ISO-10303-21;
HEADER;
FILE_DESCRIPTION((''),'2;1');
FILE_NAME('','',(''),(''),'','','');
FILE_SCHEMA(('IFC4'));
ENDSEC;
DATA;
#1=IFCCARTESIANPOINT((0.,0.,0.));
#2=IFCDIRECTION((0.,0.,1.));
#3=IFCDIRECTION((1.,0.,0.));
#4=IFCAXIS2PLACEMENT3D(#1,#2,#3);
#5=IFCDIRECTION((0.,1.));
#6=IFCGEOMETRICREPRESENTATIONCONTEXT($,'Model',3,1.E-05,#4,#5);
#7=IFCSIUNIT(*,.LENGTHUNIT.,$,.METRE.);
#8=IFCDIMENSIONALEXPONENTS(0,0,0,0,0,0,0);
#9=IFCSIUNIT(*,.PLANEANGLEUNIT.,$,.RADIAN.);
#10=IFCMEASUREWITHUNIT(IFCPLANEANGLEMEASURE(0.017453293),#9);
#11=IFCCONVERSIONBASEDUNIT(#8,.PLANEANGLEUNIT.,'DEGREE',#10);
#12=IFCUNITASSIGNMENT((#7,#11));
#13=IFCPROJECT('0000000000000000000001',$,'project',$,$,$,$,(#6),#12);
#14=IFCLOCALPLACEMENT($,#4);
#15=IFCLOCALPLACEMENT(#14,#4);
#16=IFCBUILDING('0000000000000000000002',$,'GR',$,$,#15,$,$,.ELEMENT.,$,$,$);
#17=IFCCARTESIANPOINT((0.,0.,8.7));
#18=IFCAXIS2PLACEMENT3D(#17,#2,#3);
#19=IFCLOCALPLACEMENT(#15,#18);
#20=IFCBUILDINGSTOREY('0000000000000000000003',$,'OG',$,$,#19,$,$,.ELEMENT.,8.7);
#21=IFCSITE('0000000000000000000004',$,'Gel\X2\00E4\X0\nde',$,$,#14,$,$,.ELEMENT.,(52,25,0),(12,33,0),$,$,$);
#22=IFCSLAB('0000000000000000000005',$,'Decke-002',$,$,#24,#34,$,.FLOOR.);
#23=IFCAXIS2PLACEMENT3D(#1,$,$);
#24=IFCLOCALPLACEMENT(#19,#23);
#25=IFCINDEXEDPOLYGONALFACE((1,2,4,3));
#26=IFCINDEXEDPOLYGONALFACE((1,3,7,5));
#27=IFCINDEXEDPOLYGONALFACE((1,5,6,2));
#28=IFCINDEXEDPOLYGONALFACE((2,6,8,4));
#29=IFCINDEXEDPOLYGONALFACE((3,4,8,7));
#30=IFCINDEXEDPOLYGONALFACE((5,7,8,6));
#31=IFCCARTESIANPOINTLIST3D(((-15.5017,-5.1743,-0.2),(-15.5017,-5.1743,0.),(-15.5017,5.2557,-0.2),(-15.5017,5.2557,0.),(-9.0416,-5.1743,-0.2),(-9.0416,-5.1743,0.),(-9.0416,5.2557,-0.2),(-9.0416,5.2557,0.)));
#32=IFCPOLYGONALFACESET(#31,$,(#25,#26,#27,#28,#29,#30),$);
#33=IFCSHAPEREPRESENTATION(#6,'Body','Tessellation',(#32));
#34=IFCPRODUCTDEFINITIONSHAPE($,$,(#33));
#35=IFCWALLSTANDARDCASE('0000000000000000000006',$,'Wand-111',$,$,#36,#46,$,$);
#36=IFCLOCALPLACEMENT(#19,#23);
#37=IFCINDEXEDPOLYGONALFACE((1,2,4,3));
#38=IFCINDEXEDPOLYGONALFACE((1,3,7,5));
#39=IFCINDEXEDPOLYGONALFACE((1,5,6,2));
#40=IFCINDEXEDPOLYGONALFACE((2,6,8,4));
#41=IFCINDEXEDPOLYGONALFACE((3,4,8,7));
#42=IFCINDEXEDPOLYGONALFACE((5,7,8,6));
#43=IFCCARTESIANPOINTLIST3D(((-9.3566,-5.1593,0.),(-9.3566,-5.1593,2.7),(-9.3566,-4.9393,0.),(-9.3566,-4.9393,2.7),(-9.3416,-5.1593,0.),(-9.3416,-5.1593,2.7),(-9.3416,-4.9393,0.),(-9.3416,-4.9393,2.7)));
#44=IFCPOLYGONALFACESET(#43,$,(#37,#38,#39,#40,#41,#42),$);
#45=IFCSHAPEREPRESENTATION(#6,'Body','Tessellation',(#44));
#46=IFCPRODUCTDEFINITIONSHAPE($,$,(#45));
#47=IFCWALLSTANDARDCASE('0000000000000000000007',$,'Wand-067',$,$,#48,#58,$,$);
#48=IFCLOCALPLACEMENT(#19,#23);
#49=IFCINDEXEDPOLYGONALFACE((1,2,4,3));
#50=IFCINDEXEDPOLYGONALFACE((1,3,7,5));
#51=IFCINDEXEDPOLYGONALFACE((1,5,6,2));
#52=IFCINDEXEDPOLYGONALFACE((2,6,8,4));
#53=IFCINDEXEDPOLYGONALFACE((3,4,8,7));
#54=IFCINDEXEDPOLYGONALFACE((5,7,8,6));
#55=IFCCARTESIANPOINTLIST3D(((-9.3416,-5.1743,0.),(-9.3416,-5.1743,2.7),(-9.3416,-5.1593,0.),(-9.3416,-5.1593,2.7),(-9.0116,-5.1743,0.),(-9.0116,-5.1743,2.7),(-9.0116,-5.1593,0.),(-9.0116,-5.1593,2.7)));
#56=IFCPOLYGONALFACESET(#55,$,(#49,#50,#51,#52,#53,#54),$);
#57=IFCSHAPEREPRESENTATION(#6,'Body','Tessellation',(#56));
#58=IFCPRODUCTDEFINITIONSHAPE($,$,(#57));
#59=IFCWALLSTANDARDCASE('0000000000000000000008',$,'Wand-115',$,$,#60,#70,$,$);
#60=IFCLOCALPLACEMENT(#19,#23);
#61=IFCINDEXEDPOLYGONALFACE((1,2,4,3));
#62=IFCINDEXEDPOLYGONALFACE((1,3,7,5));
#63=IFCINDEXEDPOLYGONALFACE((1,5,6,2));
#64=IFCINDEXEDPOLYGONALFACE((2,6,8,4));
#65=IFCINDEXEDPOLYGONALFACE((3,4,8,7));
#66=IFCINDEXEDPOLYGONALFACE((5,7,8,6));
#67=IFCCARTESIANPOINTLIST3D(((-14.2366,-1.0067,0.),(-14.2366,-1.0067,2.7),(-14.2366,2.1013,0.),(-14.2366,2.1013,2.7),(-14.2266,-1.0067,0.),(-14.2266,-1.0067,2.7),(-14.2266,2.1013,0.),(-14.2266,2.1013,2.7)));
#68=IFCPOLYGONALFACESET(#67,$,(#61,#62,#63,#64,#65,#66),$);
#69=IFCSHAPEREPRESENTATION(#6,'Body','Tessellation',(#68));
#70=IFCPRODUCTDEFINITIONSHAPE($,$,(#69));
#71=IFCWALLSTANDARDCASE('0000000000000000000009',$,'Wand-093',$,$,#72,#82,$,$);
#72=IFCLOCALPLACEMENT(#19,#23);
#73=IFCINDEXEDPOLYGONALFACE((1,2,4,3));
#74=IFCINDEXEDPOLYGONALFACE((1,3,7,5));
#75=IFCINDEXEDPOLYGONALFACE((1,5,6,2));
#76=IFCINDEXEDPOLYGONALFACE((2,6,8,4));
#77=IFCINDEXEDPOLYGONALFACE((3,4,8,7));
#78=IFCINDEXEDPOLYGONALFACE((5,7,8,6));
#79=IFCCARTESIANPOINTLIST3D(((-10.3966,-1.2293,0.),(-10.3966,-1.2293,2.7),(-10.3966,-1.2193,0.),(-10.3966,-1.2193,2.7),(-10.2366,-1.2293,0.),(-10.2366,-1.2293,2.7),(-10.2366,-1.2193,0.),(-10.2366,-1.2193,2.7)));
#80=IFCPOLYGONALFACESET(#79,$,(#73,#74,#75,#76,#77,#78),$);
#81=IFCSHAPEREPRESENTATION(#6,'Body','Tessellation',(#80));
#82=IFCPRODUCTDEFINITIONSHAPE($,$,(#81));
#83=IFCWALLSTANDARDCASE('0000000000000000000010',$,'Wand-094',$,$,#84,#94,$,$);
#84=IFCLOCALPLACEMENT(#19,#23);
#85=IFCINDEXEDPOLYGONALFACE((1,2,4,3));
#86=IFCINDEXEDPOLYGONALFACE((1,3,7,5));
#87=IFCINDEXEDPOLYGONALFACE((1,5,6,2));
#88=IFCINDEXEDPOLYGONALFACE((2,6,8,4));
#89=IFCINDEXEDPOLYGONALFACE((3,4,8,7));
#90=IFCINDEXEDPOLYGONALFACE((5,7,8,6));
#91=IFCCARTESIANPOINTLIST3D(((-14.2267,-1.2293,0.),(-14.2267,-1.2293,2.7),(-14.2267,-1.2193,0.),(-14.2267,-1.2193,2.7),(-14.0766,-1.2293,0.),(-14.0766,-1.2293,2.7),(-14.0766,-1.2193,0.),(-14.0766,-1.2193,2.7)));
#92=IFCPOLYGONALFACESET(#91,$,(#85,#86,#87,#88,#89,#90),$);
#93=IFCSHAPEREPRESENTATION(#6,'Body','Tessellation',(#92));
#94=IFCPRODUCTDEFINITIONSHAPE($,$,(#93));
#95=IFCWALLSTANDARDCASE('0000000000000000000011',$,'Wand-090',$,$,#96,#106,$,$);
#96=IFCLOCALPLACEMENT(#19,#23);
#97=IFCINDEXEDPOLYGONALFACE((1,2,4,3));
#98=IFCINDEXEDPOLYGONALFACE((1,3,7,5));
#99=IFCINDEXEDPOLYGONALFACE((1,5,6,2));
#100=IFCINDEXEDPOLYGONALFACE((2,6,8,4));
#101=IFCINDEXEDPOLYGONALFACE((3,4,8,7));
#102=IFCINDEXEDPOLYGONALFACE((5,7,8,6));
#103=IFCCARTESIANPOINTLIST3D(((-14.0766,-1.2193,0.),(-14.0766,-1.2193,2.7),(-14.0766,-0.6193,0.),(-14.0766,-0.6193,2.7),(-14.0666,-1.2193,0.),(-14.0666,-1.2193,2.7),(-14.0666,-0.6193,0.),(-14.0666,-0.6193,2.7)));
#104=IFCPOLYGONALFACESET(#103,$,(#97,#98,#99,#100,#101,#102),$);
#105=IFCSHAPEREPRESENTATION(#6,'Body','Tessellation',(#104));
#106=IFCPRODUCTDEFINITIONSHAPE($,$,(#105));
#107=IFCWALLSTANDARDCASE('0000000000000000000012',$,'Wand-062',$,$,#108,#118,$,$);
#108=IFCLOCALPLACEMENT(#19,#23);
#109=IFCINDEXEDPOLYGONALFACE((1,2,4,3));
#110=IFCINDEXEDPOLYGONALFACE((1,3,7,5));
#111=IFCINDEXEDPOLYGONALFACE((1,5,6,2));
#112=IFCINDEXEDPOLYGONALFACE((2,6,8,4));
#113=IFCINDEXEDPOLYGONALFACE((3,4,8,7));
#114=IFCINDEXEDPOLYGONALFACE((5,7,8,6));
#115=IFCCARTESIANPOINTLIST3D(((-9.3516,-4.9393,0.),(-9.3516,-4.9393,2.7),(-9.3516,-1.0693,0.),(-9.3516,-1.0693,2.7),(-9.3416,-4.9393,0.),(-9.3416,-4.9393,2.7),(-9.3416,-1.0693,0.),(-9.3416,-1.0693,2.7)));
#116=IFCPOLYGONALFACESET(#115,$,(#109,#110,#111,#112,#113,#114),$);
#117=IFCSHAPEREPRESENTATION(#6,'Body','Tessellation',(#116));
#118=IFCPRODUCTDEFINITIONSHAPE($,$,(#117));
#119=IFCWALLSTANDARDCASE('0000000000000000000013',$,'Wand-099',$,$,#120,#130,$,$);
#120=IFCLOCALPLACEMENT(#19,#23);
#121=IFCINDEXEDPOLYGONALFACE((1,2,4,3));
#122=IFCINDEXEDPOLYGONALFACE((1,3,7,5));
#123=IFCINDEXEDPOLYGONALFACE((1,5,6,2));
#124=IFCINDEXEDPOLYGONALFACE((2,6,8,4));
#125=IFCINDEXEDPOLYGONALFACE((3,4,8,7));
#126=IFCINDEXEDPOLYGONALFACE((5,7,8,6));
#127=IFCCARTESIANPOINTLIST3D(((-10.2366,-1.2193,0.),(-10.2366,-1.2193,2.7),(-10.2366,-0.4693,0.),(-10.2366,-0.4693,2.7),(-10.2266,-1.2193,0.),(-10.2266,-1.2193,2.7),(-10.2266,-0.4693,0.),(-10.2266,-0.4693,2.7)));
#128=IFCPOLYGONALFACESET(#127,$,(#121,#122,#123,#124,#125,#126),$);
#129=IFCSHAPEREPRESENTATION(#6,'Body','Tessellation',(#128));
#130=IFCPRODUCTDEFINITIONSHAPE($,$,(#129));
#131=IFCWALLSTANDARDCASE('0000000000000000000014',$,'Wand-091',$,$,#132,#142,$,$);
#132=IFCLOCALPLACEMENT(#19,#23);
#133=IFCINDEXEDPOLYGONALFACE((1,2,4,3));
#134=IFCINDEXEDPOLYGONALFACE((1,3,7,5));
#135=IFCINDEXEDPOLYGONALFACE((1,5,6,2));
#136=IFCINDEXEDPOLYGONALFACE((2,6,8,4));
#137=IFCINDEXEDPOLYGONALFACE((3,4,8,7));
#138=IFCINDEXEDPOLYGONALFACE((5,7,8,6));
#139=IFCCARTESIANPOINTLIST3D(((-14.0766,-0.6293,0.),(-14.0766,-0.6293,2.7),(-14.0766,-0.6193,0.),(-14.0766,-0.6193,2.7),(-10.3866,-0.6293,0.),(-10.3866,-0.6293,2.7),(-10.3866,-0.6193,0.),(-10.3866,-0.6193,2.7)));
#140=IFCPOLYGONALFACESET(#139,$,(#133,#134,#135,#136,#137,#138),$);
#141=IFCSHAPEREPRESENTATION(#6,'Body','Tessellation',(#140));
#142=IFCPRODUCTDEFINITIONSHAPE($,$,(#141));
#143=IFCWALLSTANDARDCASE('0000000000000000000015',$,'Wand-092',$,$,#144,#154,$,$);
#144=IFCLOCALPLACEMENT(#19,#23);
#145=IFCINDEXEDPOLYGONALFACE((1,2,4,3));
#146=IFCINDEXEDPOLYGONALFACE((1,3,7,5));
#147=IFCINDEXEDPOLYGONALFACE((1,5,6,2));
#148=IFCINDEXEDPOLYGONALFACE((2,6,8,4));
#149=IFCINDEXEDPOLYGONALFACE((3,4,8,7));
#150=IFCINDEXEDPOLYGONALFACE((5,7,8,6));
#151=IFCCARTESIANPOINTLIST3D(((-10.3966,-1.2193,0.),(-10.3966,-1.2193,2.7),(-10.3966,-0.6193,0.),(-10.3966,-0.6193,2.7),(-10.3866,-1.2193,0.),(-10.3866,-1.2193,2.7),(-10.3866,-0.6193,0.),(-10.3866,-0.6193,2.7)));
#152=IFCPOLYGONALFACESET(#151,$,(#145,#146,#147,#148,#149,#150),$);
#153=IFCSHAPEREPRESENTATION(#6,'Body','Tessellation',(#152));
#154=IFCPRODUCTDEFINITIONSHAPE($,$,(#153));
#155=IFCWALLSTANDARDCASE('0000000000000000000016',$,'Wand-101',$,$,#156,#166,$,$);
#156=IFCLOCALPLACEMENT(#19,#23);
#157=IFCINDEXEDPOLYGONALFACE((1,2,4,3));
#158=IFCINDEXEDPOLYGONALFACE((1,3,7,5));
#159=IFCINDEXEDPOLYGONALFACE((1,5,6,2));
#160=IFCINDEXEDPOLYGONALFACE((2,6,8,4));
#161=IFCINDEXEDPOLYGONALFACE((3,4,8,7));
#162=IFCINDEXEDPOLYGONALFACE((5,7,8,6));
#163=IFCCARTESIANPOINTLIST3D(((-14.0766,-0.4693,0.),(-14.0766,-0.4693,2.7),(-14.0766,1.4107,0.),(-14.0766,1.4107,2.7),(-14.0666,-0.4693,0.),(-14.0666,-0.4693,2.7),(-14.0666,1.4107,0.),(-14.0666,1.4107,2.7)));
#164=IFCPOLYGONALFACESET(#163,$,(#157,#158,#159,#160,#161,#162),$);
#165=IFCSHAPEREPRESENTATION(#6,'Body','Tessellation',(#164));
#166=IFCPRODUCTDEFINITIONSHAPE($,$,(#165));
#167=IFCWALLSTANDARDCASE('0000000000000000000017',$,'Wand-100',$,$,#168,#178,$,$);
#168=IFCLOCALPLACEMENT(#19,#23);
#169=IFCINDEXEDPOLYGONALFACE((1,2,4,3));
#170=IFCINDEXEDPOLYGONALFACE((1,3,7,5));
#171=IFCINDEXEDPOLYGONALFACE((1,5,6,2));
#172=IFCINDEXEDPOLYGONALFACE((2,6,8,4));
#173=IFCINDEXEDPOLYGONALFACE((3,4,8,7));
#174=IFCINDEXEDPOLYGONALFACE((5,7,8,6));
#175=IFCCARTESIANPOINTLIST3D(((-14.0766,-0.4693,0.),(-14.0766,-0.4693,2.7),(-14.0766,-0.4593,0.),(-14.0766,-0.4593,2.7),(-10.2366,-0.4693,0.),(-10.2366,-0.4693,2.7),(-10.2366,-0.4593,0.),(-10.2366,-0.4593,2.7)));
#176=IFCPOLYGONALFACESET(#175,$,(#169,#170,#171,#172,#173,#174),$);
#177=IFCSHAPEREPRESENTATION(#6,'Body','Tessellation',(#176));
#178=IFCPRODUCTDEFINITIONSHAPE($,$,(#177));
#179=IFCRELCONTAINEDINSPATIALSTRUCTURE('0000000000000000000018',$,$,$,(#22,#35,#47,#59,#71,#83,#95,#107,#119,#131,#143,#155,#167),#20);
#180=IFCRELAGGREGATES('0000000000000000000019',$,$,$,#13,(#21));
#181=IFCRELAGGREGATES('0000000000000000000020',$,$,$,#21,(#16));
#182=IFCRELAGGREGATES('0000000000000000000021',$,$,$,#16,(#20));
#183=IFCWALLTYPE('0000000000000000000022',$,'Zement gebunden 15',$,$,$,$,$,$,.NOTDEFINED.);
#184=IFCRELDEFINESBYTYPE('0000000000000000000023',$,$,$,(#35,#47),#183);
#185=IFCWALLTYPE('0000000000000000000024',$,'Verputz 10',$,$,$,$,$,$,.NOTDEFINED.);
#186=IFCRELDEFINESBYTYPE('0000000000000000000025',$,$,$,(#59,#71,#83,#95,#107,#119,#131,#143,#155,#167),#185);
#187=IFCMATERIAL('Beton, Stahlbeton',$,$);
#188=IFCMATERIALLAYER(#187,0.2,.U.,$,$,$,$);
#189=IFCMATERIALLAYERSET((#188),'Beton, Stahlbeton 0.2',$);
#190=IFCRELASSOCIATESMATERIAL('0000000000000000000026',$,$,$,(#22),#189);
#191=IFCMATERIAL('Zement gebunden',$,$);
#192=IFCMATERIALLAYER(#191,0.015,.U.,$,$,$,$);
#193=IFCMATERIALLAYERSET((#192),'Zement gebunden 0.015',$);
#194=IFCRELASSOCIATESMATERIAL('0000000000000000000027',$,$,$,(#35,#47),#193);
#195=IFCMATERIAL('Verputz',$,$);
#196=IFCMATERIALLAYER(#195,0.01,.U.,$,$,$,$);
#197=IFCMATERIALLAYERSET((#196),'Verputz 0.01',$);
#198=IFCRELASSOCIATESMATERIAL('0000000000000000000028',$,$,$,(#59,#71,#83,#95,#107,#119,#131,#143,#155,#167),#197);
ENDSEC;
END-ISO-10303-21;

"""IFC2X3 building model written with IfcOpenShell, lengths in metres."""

from ifc_helpers import new_model, entity, si_unit, converted_unit, direction, frame, origin_with_axes, place, context, project, spatial, polyline, outline, extrude, material, layer, layer_set, layer_usage, type_object, element, save


model = new_model("IFC2X3")

# Units and contexts
model_context = context("Model", 3, precision=1e-05, world=origin_with_axes(), true_north=direction((0.0, 1.0)))
ifc_project = project(units=[si_unit("LENGTHUNIT", "METRE"), converted_unit("PLANEANGLEUNIT", "DEGREE", entity("IfcPlaneAngleMeasure", 0.017453293), si_unit("PLANEANGLEUNIT", "RADIAN"), dimensions=[0, 0, 0, 0, 0, 0, 0])], contexts=[model_context])

# Site, building, storey
site_placement = place(None, origin_with_axes())
site = spatial("IfcSite", under=ifc_project, at=site_placement, Name="Gelände", CompositionType="ELEMENT", RefLatitude=(52, 25, 0), RefLongitude=(12, 33, 0))
building_placement = place(site_placement, origin_with_axes())
building = spatial("IfcBuilding", under=site, at=building_placement, Name="GR", CompositionType="ELEMENT")
storey_placement = place(building_placement, frame((0.0, 0.0, 8.7), z_axis=(0.0, 0.0, 1.0), x_axis=(1.0, 0.0, 0.0)))
storey = spatial("IfcBuildingStorey", under=building, at=storey_placement, Name="OG", CompositionType="ELEMENT", Elevation=8.7)

# Slab
ifc_material_1 = material(Name="Beton, Stahlbeton")
ifc_layer_1 = layer(ifc_material_1, 0.2, ventilated="UNKNOWN")
ifc_layer_set_1 = layer_set([ifc_layer_1], Name="Beton, Stahlbeton 0.2")
ifc_layer_usage_1 = layer_usage(ifc_layer_set_1, "AXIS3", "NEGATIVE", 0.2)
slab_placement = place(storey_placement, frame((-9.0416, -5.1743, -0.2), z_axis=(0.0, 0.0, 1.0), x_axis=(1.0, 0.0, 0.0)))
element("IfcSlab", 1, at=slab_placement, inside=storey, material=ifc_layer_usage_1, Name="Decke-002", PredefinedType="FLOOR", context=model_context, shape_type="SweptSolid", body=[
    extrude(outline(polyline([(0.0, 0.0), (0.0, 10.43), (-6.46, 10.43), (-6.46, 0.0), (0.0, 0.0)])), origin_with_axes(), (0.0, 0.0, 1.0), 0.2),
])

# Walls
ifc_material_2 = material(Name="Zement gebunden")
ifc_layer_2 = layer(ifc_material_2, 0.015, ventilated="UNKNOWN")
ifc_layer_set_2 = layer_set([ifc_layer_2], Name="Zement gebunden 0.015")
ifc_layer_usage_2 = layer_usage(ifc_layer_set_2, "AXIS2", "NEGATIVE", 0.0)
wall_type_1 = type_object("IfcWallType", Name="Zement gebunden 15", PredefinedType="NOTDEFINED")
wall_1_placement = place(storey_placement, frame((-9.3416, -4.9393, 0.0), z_axis=(0.0, 0.0, 1.0), x_axis=(0.0, -1.0, 0.0)))
element("IfcWallStandardCase", 2, at=wall_1_placement, inside=storey, type_object=wall_type_1, material=ifc_layer_usage_2, Name="Wand-111", context=model_context, shape_type="SweptSolid", body=[
    extrude(outline(polyline([(0.0, -0.015), (0.22, -0.015), (0.22, 0.0), (0.0, 0.0), (0.0, -0.015)])), origin_with_axes(), (0.0, 0.0, 1.0), 2.7),
])
ifc_layer_usage_3 = layer_usage(ifc_layer_set_2, "AXIS2", "NEGATIVE", 0.0)
wall_2_placement = place(storey_placement, frame((-9.3416, -5.1593, 0.0), z_axis=(0.0, 0.0, 1.0), x_axis=(1.0, 0.0, 0.0)))
element("IfcWallStandardCase", 3, at=wall_2_placement, inside=storey, type_object=wall_type_1, material=ifc_layer_usage_3, Name="Wand-067", context=model_context, shape_type="SweptSolid", body=[
    extrude(outline(polyline([(0.0, -0.015), (0.33, -0.015), (0.33, 0.0), (0.0, 0.0), (0.0, -0.015)])), origin_with_axes(), (0.0, 0.0, 1.0), 2.7),
])
ifc_material_3 = material(Name="Verputz")
ifc_layer_3 = layer(ifc_material_3, 0.01, ventilated="UNKNOWN")
ifc_layer_set_3 = layer_set([ifc_layer_3], Name="Verputz 0.01")
ifc_layer_usage_4 = layer_usage(ifc_layer_set_3, "AXIS2", "POSITIVE", 0.0)
wall_type_2 = type_object("IfcWallType", Name="Verputz 10", PredefinedType="NOTDEFINED")
wall_3_placement = place(storey_placement, frame((-14.2266, -1.0067, 0.0), z_axis=(0.0, 0.0, 1.0), x_axis=(0.0, 1.0, 0.0)))
element("IfcWallStandardCase", 4, at=wall_3_placement, inside=storey, type_object=wall_type_2, material=ifc_layer_usage_4, Name="Wand-115", context=model_context, shape_type="SweptSolid", body=[
    extrude(outline(polyline([(0.0, 0.0), (3.1079, 0.0), (3.1079, 0.01), (0.0, 0.01), (0.0, 0.0)])), origin_with_axes(), (0.0, 0.0, 1.0), 2.7),
])
ifc_layer_usage_5 = layer_usage(ifc_layer_set_3, "AXIS2", "NEGATIVE", 0.0)
wall_4_placement = place(storey_placement, frame((-10.3966, -1.2193, 0.0), z_axis=(0.0, 0.0, 1.0), x_axis=(1.0, 0.0, 0.0)))
element("IfcWallStandardCase", 5, at=wall_4_placement, inside=storey, type_object=wall_type_2, material=ifc_layer_usage_5, Name="Wand-093", context=model_context, shape_type="SweptSolid", body=[
    extrude(outline(polyline([(0.0, -0.01), (0.16, -0.01), (0.16, 0.0), (0.0, 0.0), (0.0, -0.01)])), origin_with_axes(), (0.0, 0.0, 1.0), 2.7),
])
ifc_layer_usage_6 = layer_usage(ifc_layer_set_3, "AXIS2", "NEGATIVE", 0.0)
wall_5_placement = place(storey_placement, frame((-14.2267, -1.2193, 0.0), z_axis=(0.0, 0.0, 1.0), x_axis=(1.0, 0.0, 0.0)))
element("IfcWallStandardCase", 6, at=wall_5_placement, inside=storey, type_object=wall_type_2, material=ifc_layer_usage_6, Name="Wand-094", context=model_context, shape_type="SweptSolid", body=[
    extrude(outline(polyline([(0.0, -0.01), (0.15, -0.01), (0.15, 0.0), (0.0, 0.0), (0.0, -0.01)])), origin_with_axes(), (0.0, 0.0, 1.0), 2.7),
])
ifc_layer_usage_7 = layer_usage(ifc_layer_set_3, "AXIS2", "NEGATIVE", 0.0)
wall_6_placement = place(storey_placement, frame((-14.0766, -1.2193, 0.0), z_axis=(0.0, 0.0, 1.0), x_axis=(0.0, 1.0, 0.0)))
element("IfcWallStandardCase", 7, at=wall_6_placement, inside=storey, type_object=wall_type_2, material=ifc_layer_usage_7, Name="Wand-090", context=model_context, shape_type="SweptSolid", body=[
    extrude(outline(polyline([(0.0, -0.01), (0.6, -0.01), (0.6, 0.0), (0.0, 0.0), (0.0, -0.01)])), origin_with_axes(), (0.0, 0.0, 1.0), 2.7),
])
ifc_layer_usage_8 = layer_usage(ifc_layer_set_3, "AXIS2", "NEGATIVE", 0.0)
wall_7_placement = place(storey_placement, frame((-9.3416, -1.0693, 0.0), z_axis=(0.0, 0.0, 1.0), x_axis=(0.0, -1.0, 0.0)))
element("IfcWallStandardCase", 8, at=wall_7_placement, inside=storey, type_object=wall_type_2, material=ifc_layer_usage_8, Name="Wand-062", context=model_context, shape_type="SweptSolid", body=[
    extrude(outline(polyline([(0.0, -0.01), (3.87, -0.01), (3.87, 0.0), (0.0, 0.0), (0.0, -0.01)])), origin_with_axes(), (0.0, 0.0, 1.0), 2.7),
])
ifc_layer_usage_9 = layer_usage(ifc_layer_set_3, "AXIS2", "NEGATIVE", 0.0)
wall_8_placement = place(storey_placement, frame((-10.2366, -1.2193, 0.0), z_axis=(0.0, 0.0, 1.0), x_axis=(0.0, 1.0, 0.0)))
element("IfcWallStandardCase", 9, at=wall_8_placement, inside=storey, type_object=wall_type_2, material=ifc_layer_usage_9, Name="Wand-099", context=model_context, shape_type="SweptSolid", body=[
    extrude(outline(polyline([(0.0, -0.01), (0.75, -0.01), (0.75, 0.0), (0.0, 0.0), (0.0, -0.01)])), origin_with_axes(), (0.0, 0.0, 1.0), 2.7),
])
ifc_layer_usage_10 = layer_usage(ifc_layer_set_3, "AXIS2", "NEGATIVE", 0.0)
wall_9_placement = place(storey_placement, frame((-14.0766, -0.6193, 0.0), z_axis=(0.0, 0.0, 1.0), x_axis=(1.0, 0.0, 0.0)))
element("IfcWallStandardCase", 10, at=wall_9_placement, inside=storey, type_object=wall_type_2, material=ifc_layer_usage_10, Name="Wand-091", context=model_context, shape_type="SweptSolid", body=[
    extrude(outline(polyline([(0.0, -0.01), (3.69, -0.01), (3.69, 0.0), (0.0, 0.0), (0.0, -0.01)])), origin_with_axes(), (0.0, 0.0, 1.0), 2.7),
])
ifc_layer_usage_11 = layer_usage(ifc_layer_set_3, "AXIS2", "NEGATIVE", 0.0)
wall_10_placement = place(storey_placement, frame((-10.3866, -0.6193, 0.0), z_axis=(0.0, 0.0, 1.0), x_axis=(0.0, -1.0, 0.0)))
element("IfcWallStandardCase", 11, at=wall_10_placement, inside=storey, type_object=wall_type_2, material=ifc_layer_usage_11, Name="Wand-092", context=model_context, shape_type="SweptSolid", body=[
    extrude(outline(polyline([(0.0, -0.01), (0.6, -0.01), (0.6, 0.0), (0.0, 0.0), (0.0, -0.01)])), origin_with_axes(), (0.0, 0.0, 1.0), 2.7),
])
ifc_layer_usage_12 = layer_usage(ifc_layer_set_3, "AXIS2", "NEGATIVE", 0.0)
wall_11_placement = place(storey_placement, frame((-14.0766, -0.4693, 0.0), z_axis=(0.0, 0.0, 1.0), x_axis=(0.0, 1.0, 0.0)))
element("IfcWallStandardCase", 12, at=wall_11_placement, inside=storey, type_object=wall_type_2, material=ifc_layer_usage_12, Name="Wand-101", context=model_context, shape_type="SweptSolid", body=[
    extrude(outline(polyline([(0.0, -0.01), (1.88, -0.01), (1.88, 0.0), (0.0, 0.0), (0.0, -0.01)])), origin_with_axes(), (0.0, 0.0, 1.0), 2.7),
])
ifc_layer_usage_13 = layer_usage(ifc_layer_set_3, "AXIS2", "NEGATIVE", 0.0)
wall_12_placement = place(storey_placement, frame((-10.2366, -0.4693, 0.0), z_axis=(0.0, 0.0, 1.0), x_axis=(-1.0, 0.0, 0.0)))
element("IfcWallStandardCase", 13, at=wall_12_placement, inside=storey, type_object=wall_type_2, material=ifc_layer_usage_13, Name="Wand-100", context=model_context, shape_type="SweptSolid", body=[
    extrude(outline(polyline([(0.0, -0.01), (3.84, -0.01), (3.84, 0.0), (0.0, 0.0), (0.0, -0.01)])), origin_with_axes(), (0.0, 0.0, 1.0), 2.7),
])

save(model, "model.ifc")
